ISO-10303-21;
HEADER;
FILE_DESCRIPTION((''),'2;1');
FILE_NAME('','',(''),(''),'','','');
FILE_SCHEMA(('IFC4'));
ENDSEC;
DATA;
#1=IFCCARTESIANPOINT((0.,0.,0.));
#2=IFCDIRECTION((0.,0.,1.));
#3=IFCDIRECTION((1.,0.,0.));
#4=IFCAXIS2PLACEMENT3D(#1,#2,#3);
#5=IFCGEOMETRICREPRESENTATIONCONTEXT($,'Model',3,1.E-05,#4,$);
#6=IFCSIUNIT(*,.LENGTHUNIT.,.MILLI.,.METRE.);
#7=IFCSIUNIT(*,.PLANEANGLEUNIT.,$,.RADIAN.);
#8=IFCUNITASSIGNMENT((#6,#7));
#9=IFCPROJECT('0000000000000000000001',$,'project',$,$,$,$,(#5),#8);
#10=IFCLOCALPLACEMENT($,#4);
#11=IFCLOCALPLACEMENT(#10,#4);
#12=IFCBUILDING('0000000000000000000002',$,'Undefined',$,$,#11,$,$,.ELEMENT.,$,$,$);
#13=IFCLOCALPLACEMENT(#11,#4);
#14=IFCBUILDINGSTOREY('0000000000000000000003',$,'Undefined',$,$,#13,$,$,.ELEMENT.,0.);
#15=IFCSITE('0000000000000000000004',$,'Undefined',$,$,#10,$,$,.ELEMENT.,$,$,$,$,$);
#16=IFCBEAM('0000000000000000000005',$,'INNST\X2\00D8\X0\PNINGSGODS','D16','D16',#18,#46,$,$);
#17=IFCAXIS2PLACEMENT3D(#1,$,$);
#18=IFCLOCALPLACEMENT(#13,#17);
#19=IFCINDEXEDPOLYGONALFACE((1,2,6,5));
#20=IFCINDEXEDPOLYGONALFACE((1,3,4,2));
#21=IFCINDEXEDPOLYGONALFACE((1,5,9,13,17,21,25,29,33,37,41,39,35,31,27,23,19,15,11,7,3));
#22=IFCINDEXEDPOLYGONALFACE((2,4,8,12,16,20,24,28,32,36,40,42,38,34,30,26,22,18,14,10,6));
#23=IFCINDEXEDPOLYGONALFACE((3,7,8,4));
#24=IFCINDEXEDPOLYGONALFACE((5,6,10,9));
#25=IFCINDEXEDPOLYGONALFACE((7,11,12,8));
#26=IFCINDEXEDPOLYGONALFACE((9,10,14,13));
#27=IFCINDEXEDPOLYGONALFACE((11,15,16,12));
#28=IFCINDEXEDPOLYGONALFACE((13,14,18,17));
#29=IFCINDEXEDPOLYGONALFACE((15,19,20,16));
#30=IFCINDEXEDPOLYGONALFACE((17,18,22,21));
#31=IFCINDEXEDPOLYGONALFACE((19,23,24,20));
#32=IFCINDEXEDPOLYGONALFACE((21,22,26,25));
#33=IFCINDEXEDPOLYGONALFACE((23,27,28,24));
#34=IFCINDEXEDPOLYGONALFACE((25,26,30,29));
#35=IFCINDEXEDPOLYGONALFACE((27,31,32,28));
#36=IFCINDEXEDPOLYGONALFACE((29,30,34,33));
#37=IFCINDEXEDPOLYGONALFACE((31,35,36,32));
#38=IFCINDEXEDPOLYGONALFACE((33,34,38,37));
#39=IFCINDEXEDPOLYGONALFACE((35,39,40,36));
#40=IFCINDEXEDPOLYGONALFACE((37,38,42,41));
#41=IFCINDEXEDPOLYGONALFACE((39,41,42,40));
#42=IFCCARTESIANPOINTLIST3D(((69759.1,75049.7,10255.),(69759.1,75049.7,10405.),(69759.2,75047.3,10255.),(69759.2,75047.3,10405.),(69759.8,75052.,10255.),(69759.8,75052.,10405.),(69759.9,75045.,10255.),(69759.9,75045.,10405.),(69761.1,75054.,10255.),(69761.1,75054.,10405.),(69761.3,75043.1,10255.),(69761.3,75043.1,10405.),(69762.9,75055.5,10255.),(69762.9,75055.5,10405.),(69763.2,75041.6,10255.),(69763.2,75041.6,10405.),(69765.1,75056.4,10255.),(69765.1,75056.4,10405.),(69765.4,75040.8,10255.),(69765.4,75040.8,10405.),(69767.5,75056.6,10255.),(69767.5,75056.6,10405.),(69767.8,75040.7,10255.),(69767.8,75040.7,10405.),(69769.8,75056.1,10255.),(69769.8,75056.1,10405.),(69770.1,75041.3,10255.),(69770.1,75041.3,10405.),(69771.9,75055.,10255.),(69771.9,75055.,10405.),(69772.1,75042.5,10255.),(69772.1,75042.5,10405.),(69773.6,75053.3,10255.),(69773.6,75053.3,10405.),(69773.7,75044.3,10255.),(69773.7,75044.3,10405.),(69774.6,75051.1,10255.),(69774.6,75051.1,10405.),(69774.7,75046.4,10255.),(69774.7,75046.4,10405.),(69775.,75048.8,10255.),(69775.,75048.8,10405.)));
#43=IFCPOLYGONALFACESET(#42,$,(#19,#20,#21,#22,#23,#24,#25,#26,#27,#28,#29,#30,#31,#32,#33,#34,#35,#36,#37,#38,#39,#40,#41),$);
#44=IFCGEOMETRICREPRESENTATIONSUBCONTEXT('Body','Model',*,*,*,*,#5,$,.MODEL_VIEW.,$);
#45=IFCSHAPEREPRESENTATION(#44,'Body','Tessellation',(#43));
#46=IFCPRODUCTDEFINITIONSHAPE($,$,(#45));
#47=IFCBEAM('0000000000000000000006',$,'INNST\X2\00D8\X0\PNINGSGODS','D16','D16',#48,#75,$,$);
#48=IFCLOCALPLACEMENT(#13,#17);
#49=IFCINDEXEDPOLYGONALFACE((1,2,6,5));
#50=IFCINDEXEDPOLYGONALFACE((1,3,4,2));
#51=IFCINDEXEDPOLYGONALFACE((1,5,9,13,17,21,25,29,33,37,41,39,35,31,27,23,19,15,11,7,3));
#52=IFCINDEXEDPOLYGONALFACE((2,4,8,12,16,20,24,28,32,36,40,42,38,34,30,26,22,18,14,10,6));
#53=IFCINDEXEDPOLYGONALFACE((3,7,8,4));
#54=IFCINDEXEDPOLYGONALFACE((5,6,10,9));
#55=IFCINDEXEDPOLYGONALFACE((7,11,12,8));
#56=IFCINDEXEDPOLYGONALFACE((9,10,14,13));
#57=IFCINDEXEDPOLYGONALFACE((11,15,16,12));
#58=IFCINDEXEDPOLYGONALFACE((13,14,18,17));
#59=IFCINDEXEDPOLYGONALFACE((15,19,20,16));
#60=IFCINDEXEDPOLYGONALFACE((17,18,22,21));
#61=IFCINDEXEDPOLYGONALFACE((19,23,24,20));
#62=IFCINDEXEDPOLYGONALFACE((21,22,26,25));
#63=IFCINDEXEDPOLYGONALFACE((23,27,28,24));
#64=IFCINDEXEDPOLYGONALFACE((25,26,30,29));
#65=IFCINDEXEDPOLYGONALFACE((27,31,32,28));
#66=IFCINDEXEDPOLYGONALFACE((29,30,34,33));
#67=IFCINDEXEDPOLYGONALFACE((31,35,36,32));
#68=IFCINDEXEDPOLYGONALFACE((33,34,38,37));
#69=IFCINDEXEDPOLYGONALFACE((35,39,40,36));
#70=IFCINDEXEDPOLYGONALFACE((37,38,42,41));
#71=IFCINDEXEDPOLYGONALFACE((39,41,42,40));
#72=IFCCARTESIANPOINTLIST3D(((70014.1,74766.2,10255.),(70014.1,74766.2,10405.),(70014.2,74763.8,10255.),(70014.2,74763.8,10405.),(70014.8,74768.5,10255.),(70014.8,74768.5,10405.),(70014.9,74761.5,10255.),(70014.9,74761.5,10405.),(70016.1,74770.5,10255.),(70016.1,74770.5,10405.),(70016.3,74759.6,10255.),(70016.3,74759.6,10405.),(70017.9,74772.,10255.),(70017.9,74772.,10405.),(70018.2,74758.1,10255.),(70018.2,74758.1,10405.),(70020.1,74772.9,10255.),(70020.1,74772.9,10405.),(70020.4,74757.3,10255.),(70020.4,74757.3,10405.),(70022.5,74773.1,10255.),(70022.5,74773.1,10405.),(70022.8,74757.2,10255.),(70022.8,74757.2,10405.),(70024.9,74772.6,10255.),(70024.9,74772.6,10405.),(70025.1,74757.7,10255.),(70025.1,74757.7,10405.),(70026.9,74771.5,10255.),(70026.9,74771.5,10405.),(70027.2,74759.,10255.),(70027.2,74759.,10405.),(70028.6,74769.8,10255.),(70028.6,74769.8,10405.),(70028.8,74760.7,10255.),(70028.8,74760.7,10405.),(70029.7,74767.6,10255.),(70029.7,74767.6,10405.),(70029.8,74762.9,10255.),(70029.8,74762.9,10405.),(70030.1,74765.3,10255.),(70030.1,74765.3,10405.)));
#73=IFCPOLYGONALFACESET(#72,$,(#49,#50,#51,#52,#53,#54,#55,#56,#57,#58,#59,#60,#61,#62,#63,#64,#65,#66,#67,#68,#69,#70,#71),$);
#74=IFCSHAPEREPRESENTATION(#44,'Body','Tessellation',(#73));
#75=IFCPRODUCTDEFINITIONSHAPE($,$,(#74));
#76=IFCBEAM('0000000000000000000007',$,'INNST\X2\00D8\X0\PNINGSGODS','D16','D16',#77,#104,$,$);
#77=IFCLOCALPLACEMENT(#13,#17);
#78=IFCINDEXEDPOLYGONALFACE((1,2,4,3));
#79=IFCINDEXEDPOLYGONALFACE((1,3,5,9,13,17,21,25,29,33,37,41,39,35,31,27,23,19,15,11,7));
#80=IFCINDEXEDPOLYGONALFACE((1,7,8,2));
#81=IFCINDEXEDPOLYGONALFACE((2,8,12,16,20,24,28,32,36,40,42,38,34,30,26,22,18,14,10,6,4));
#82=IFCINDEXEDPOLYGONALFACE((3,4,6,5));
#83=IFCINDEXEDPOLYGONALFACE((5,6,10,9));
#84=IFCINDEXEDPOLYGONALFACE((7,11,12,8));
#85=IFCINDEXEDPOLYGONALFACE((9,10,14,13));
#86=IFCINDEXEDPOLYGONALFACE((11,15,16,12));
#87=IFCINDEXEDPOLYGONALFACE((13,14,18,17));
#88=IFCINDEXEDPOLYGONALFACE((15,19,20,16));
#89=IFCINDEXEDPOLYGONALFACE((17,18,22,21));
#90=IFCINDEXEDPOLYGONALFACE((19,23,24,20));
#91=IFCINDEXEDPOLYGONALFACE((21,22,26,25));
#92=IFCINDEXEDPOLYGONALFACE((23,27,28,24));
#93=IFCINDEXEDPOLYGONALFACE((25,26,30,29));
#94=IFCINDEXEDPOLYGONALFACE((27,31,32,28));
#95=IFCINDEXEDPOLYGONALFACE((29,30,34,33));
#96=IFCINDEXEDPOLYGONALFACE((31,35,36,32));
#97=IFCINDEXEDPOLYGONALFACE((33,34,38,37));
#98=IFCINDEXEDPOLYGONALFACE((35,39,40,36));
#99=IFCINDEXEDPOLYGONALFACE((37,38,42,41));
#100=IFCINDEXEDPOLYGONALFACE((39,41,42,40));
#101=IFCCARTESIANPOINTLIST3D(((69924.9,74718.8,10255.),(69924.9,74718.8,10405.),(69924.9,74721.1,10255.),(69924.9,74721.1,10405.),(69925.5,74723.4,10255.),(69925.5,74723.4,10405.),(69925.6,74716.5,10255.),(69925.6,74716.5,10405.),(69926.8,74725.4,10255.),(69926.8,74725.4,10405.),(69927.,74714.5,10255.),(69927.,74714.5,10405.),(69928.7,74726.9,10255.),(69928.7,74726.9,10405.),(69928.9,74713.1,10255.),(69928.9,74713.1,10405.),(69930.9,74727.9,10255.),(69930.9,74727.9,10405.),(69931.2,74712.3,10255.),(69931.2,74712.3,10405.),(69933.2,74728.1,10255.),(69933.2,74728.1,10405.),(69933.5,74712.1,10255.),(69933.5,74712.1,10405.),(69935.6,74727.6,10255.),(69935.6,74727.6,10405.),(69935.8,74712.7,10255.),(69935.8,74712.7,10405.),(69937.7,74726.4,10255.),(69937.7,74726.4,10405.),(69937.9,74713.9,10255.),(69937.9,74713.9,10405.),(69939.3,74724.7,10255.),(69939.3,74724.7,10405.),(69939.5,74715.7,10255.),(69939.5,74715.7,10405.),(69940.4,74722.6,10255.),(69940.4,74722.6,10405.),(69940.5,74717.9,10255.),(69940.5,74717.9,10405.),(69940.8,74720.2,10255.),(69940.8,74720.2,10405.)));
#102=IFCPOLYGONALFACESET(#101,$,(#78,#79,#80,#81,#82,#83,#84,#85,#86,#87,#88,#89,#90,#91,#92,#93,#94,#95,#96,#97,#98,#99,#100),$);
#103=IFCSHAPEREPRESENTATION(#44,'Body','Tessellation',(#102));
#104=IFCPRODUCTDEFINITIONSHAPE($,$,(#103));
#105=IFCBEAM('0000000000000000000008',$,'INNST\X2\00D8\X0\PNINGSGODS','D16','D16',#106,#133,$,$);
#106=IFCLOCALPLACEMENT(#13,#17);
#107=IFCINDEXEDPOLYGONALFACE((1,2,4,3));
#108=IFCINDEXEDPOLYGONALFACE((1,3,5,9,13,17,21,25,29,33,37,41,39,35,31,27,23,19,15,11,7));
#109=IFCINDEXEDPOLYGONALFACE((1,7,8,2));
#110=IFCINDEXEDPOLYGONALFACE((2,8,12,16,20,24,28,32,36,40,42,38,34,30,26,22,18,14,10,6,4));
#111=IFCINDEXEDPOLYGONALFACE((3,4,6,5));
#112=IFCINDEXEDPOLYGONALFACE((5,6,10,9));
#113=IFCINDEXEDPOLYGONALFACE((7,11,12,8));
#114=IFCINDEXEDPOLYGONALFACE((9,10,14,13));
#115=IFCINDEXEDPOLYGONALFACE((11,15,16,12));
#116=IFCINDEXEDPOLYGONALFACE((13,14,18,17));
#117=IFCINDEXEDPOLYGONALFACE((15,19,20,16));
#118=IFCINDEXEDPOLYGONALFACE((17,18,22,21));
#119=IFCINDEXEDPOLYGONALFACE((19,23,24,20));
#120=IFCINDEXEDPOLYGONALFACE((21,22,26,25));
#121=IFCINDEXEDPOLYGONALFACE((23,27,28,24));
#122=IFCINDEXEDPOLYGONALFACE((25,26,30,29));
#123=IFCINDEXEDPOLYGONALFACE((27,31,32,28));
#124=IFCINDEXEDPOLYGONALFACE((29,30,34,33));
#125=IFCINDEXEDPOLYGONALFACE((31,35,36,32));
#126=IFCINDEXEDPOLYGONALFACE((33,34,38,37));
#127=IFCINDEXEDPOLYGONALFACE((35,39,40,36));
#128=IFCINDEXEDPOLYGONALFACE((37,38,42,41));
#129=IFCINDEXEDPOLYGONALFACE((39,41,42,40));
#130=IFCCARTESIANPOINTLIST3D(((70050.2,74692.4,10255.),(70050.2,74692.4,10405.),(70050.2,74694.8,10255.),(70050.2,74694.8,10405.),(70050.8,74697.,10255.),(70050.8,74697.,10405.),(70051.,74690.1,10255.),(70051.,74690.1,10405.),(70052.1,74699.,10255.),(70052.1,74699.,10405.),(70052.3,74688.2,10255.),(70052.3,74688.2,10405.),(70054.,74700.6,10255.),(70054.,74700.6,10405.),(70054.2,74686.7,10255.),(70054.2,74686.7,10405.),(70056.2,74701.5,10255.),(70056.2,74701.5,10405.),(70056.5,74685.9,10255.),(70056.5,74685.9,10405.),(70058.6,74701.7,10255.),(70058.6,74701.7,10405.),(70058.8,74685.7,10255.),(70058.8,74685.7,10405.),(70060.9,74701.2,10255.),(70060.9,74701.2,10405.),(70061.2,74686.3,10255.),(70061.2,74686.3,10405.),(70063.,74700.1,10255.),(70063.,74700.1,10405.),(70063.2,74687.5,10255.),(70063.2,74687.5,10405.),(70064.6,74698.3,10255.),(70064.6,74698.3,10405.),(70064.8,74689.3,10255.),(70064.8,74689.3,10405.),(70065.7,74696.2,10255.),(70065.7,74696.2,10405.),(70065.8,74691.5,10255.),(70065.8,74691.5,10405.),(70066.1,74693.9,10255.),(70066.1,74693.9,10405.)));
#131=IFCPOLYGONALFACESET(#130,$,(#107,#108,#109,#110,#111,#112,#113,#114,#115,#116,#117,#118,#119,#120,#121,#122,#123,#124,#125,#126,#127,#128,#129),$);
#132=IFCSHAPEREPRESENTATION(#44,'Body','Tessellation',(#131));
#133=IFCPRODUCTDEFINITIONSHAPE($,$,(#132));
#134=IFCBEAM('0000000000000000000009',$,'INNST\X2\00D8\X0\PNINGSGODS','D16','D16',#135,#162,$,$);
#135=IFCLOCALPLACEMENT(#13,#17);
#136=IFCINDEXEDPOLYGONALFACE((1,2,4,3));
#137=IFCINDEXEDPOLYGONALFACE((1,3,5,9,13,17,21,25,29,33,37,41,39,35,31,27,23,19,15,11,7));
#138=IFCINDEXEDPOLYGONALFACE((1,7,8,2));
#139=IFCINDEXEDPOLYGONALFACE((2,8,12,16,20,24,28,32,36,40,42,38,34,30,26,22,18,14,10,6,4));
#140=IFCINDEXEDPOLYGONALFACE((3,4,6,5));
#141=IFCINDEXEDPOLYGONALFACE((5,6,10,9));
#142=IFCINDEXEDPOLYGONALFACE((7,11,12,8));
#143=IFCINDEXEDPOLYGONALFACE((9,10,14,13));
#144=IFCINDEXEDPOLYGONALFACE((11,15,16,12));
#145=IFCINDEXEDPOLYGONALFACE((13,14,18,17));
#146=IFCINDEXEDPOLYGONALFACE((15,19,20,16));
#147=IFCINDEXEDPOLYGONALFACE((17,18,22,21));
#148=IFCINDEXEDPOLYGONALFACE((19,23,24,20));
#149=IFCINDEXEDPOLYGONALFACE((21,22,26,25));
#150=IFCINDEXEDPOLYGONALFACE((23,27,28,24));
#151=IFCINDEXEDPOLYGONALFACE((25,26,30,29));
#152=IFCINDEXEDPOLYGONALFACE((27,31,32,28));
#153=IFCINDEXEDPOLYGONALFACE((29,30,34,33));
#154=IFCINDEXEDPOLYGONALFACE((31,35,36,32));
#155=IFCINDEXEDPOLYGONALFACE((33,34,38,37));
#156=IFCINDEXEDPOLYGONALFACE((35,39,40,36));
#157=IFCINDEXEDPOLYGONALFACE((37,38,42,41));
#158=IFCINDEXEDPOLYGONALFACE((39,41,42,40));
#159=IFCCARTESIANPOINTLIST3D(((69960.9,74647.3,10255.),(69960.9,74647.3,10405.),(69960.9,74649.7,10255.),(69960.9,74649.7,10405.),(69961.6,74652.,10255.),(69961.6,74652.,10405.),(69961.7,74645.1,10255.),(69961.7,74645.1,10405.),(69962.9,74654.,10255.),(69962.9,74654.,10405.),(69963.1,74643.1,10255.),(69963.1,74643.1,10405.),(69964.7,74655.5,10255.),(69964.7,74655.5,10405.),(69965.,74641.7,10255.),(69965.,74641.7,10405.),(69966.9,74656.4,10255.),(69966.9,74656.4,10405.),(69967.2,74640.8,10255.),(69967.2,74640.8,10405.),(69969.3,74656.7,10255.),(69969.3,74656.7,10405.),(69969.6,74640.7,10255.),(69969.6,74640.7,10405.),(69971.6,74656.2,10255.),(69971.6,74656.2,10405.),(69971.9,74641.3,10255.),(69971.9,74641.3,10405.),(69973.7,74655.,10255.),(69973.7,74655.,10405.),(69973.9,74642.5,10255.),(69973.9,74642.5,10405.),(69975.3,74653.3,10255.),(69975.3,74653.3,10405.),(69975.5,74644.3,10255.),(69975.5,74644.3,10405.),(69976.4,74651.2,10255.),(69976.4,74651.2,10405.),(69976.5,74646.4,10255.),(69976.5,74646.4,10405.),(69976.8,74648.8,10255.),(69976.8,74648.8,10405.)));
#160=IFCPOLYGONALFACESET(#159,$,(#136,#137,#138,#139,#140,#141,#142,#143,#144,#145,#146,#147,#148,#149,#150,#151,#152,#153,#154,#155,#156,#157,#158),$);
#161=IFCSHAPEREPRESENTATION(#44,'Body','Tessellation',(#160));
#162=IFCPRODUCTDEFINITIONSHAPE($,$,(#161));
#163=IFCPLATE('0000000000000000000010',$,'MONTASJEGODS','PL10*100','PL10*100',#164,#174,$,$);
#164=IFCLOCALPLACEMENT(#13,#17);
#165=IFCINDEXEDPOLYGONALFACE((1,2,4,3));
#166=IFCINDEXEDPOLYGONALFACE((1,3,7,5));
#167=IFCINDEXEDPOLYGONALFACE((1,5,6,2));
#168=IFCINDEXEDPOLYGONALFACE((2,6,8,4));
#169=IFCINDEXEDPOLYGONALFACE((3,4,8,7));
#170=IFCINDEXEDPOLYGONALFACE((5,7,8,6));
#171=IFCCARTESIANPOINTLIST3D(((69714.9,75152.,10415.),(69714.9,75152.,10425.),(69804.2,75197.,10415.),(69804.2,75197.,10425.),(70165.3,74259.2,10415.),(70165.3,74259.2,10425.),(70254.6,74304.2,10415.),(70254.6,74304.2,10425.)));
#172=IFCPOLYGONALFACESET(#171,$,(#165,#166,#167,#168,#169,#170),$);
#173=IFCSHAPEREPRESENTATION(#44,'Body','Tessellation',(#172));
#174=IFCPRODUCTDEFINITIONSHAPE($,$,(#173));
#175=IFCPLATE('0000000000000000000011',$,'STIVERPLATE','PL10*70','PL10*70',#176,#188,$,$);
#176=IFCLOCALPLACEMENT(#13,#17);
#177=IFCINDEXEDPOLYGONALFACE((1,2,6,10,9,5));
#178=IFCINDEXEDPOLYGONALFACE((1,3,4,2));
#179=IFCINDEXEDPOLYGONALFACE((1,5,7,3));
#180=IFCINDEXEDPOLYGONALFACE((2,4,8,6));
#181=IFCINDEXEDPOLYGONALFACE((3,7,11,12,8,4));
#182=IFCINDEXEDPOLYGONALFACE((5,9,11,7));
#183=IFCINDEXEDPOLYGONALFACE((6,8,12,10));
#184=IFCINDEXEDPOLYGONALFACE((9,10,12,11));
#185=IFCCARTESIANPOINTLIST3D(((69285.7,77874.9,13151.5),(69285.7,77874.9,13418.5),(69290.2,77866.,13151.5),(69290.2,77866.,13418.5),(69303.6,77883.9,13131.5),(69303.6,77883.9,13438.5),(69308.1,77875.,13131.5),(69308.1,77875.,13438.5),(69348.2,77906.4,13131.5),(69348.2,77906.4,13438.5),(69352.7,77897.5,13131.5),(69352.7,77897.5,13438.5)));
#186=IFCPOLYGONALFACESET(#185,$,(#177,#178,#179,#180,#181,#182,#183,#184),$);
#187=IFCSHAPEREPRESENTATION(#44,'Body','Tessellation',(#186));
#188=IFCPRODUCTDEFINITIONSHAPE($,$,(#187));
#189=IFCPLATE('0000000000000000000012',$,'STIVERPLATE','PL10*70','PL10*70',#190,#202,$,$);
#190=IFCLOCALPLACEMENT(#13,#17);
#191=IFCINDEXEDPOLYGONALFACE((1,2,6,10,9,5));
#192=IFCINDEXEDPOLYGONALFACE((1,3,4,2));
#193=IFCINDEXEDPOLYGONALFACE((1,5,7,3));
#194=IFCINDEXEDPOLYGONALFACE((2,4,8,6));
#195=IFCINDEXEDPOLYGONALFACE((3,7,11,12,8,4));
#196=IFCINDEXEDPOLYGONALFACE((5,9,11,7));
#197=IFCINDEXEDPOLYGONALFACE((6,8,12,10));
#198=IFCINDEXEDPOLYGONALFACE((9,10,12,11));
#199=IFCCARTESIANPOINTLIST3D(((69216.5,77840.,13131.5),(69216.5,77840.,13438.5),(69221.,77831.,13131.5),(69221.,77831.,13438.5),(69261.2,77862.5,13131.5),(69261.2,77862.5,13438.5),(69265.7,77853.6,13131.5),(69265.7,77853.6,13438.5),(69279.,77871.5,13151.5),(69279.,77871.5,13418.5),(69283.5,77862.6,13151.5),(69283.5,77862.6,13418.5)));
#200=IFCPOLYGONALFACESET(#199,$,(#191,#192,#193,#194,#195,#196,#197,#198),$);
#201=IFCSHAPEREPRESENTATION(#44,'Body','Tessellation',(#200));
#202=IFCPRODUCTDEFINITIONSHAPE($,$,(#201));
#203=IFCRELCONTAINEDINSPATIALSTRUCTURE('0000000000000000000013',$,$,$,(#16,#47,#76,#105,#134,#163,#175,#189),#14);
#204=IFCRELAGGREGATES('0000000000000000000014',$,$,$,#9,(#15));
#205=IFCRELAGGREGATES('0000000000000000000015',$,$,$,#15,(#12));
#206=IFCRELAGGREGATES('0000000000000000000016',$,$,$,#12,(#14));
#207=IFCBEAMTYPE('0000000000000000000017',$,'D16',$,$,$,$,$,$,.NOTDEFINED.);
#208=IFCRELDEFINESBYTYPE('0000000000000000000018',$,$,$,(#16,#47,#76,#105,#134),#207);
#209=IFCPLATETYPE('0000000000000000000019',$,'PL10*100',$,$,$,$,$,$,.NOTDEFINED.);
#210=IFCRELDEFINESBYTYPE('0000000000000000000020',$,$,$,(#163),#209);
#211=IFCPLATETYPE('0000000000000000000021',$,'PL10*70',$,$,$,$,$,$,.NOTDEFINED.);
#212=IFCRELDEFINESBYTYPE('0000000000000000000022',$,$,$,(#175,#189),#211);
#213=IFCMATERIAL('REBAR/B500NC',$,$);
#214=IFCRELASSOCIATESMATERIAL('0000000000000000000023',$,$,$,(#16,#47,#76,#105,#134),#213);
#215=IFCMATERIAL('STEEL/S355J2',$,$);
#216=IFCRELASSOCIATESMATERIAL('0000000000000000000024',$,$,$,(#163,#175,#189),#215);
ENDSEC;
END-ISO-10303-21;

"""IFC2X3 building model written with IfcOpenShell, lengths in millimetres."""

from ifc_helpers import new_model, si_unit, frame, origin_with_axes, origin_2d_with_axis, place, context, subcontext, project, spatial, polyline, circle, outline, extrude, material, type_object, element, save


model = new_model("IFC2X3")

# Units and contexts
model_context = context("Model", 3, precision=1e-05, world=origin_with_axes())
body_context = subcontext(model_context, "Body", "Model", "MODEL_VIEW")
ifc_project = project(units=[si_unit("LENGTHUNIT", "METRE", prefix="MILLI"), si_unit("PLANEANGLEUNIT", "RADIAN")], contexts=[model_context])

# Site, building, storey
site_placement = place(None, origin_with_axes())
site = spatial("IfcSite", under=ifc_project, at=site_placement, Name="Undefined", CompositionType="ELEMENT")
building_placement = place(site_placement, origin_with_axes())
building = spatial("IfcBuilding", under=site, at=building_placement, Name="Undefined", CompositionType="ELEMENT")
storey_placement = place(building_placement, origin_with_axes())
storey = spatial("IfcBuildingStorey", under=building, at=storey_placement, Name="Undefined", CompositionType="ELEMENT", Elevation=0.0)

# Shared definitions
ifc_material_1 = material(Name="REBAR/B500NC")

# Beams
beam_type = type_object("IfcBeamType", Name="D16", PredefinedType="NOTDEFINED")
for number, where, z_axis, x_axis, name in (
    (1, (69767.0, 75048.6, 10405.0), (0.450411, -0.892821, 0.0), (0.0, 0.0, -1.0), "INNSTØPNINGSGODS"),
    (2, (70022.1, 74765.1, 10405.0), (0.450411, -0.892821, 0.0), (0.0, 0.0, -1.0), "INNSTØPNINGSGODS"),
    (3, (69932.8, 74720.1, 10405.0), (0.450411, -0.892821, 0.0), (0.0, 0.0, -1.0), "INNSTØPNINGSGODS"),
    (4, (70058.1, 74693.7, 10405.0), (0.450411, -0.892821, 0.0), (0.0, 0.0, -1.0), "INNSTØPNINGSGODS"),
    (5, (69968.8, 74648.7, 10405.0), (0.450411, -0.892821, 0.0), (0.0, 0.0, -1.0), "INNSTØPNINGSGODS"),
):
    element("IfcBeam", number, at=place(storey_placement, frame(where, z_axis=z_axis, x_axis=x_axis)), inside=storey, type_object=beam_type, material=ifc_material_1, Name=name, Description="D16", ObjectType="D16", context=body_context, shape_type="SweptSolid", body=[
        extrude(circle(Radius=8.0, at=origin_2d_with_axis()), frame((150.0, 0.0, 0.0), z_axis=(-1.0, 0.0, 0.0), x_axis=(0.0, -1.0, 0.0)), (0.0, 0.0, 1.0), 150.0),
    ])

# Plates
ifc_material_2 = material(Name="STEEL/S355J2")
plate_type_1 = type_object("IfcPlateType", Name="PL10*100", PredefinedType="NOTDEFINED")
plate_1_placement = place(storey_placement, frame((69714.9, 75152.0, 10420.0), z_axis=(0.0, 0.0, 1.0), x_axis=(0.450411, -0.892821, 0.0)))
element("IfcPlate", 6, at=plate_1_placement, inside=storey, type_object=plate_type_1, material=ifc_material_2, Name="MONTASJEGODS", Description="PL10*100", ObjectType="PL10*100", context=body_context, shape_type="SweptSolid", body=[
    extrude(outline(polyline([(0.0, 0.0), (1000.0, 0.0), (1000.0, 100.0), (0.0, 100.0), (0.0, 0.0)])), frame((0.0, 0.0, -5.0), z_axis=(0.0, 0.0, 1.0), x_axis=(1.0, 0.0, 0.0)), (0.0, 0.0, 1.0), 10.0),
])
plate_type_2 = type_object("IfcPlateType", Name="PL10*70", PredefinedType="NOTDEFINED")
plate_2_placement = place(storey_placement, frame((69350.5, 77901.9, 13131.5), z_axis=(-0.450411, 0.892821, 0.0), x_axis=(-0.892821, -0.450411, 0.0)))
element("IfcPlate", 7, at=plate_2_placement, inside=storey, type_object=plate_type_2, material=ifc_material_2, Name="STIVERPLATE", Description="PL10*70", ObjectType="PL10*70", context=body_context, shape_type="SweptSolid", body=[
    extrude(outline(polyline([(0.0, 0.0), (50.0, 0.0), (70.0, 20.0), (70.0, 287.0), (50.0, 307.0), (0.0, 307.0), (0.0, 0.0)])), frame((0.0, 0.0, -5.0), z_axis=(0.0, 0.0, 1.0), x_axis=(1.0, 0.0, 0.0)), (0.0, 0.0, 1.0), 10.0),
])
plate_3_placement = place(storey_placement, frame((69281.3, 77867.0, 13131.5), z_axis=(-0.450411, 0.892821, 0.0), x_axis=(-0.892821, -0.450411, 0.0)))
element("IfcPlate", 8, at=plate_3_placement, inside=storey, type_object=plate_type_2, material=ifc_material_2, Name="STIVERPLATE", Description="PL10*70", ObjectType="PL10*70", context=body_context, shape_type="SweptSolid", body=[
    extrude(outline(polyline([(0.0, 20.0), (20.0, 0.0), (70.0, 0.0), (70.0, 307.0), (20.0, 307.0), (0.0, 287.0), (0.0, 20.0)])), frame((0.0, 0.0, -5.0), z_axis=(0.0, 0.0, 1.0), x_axis=(1.0, 0.0, 0.0)), (0.0, 0.0, 1.0), 10.0),
])

save(model, "model.ifc")
